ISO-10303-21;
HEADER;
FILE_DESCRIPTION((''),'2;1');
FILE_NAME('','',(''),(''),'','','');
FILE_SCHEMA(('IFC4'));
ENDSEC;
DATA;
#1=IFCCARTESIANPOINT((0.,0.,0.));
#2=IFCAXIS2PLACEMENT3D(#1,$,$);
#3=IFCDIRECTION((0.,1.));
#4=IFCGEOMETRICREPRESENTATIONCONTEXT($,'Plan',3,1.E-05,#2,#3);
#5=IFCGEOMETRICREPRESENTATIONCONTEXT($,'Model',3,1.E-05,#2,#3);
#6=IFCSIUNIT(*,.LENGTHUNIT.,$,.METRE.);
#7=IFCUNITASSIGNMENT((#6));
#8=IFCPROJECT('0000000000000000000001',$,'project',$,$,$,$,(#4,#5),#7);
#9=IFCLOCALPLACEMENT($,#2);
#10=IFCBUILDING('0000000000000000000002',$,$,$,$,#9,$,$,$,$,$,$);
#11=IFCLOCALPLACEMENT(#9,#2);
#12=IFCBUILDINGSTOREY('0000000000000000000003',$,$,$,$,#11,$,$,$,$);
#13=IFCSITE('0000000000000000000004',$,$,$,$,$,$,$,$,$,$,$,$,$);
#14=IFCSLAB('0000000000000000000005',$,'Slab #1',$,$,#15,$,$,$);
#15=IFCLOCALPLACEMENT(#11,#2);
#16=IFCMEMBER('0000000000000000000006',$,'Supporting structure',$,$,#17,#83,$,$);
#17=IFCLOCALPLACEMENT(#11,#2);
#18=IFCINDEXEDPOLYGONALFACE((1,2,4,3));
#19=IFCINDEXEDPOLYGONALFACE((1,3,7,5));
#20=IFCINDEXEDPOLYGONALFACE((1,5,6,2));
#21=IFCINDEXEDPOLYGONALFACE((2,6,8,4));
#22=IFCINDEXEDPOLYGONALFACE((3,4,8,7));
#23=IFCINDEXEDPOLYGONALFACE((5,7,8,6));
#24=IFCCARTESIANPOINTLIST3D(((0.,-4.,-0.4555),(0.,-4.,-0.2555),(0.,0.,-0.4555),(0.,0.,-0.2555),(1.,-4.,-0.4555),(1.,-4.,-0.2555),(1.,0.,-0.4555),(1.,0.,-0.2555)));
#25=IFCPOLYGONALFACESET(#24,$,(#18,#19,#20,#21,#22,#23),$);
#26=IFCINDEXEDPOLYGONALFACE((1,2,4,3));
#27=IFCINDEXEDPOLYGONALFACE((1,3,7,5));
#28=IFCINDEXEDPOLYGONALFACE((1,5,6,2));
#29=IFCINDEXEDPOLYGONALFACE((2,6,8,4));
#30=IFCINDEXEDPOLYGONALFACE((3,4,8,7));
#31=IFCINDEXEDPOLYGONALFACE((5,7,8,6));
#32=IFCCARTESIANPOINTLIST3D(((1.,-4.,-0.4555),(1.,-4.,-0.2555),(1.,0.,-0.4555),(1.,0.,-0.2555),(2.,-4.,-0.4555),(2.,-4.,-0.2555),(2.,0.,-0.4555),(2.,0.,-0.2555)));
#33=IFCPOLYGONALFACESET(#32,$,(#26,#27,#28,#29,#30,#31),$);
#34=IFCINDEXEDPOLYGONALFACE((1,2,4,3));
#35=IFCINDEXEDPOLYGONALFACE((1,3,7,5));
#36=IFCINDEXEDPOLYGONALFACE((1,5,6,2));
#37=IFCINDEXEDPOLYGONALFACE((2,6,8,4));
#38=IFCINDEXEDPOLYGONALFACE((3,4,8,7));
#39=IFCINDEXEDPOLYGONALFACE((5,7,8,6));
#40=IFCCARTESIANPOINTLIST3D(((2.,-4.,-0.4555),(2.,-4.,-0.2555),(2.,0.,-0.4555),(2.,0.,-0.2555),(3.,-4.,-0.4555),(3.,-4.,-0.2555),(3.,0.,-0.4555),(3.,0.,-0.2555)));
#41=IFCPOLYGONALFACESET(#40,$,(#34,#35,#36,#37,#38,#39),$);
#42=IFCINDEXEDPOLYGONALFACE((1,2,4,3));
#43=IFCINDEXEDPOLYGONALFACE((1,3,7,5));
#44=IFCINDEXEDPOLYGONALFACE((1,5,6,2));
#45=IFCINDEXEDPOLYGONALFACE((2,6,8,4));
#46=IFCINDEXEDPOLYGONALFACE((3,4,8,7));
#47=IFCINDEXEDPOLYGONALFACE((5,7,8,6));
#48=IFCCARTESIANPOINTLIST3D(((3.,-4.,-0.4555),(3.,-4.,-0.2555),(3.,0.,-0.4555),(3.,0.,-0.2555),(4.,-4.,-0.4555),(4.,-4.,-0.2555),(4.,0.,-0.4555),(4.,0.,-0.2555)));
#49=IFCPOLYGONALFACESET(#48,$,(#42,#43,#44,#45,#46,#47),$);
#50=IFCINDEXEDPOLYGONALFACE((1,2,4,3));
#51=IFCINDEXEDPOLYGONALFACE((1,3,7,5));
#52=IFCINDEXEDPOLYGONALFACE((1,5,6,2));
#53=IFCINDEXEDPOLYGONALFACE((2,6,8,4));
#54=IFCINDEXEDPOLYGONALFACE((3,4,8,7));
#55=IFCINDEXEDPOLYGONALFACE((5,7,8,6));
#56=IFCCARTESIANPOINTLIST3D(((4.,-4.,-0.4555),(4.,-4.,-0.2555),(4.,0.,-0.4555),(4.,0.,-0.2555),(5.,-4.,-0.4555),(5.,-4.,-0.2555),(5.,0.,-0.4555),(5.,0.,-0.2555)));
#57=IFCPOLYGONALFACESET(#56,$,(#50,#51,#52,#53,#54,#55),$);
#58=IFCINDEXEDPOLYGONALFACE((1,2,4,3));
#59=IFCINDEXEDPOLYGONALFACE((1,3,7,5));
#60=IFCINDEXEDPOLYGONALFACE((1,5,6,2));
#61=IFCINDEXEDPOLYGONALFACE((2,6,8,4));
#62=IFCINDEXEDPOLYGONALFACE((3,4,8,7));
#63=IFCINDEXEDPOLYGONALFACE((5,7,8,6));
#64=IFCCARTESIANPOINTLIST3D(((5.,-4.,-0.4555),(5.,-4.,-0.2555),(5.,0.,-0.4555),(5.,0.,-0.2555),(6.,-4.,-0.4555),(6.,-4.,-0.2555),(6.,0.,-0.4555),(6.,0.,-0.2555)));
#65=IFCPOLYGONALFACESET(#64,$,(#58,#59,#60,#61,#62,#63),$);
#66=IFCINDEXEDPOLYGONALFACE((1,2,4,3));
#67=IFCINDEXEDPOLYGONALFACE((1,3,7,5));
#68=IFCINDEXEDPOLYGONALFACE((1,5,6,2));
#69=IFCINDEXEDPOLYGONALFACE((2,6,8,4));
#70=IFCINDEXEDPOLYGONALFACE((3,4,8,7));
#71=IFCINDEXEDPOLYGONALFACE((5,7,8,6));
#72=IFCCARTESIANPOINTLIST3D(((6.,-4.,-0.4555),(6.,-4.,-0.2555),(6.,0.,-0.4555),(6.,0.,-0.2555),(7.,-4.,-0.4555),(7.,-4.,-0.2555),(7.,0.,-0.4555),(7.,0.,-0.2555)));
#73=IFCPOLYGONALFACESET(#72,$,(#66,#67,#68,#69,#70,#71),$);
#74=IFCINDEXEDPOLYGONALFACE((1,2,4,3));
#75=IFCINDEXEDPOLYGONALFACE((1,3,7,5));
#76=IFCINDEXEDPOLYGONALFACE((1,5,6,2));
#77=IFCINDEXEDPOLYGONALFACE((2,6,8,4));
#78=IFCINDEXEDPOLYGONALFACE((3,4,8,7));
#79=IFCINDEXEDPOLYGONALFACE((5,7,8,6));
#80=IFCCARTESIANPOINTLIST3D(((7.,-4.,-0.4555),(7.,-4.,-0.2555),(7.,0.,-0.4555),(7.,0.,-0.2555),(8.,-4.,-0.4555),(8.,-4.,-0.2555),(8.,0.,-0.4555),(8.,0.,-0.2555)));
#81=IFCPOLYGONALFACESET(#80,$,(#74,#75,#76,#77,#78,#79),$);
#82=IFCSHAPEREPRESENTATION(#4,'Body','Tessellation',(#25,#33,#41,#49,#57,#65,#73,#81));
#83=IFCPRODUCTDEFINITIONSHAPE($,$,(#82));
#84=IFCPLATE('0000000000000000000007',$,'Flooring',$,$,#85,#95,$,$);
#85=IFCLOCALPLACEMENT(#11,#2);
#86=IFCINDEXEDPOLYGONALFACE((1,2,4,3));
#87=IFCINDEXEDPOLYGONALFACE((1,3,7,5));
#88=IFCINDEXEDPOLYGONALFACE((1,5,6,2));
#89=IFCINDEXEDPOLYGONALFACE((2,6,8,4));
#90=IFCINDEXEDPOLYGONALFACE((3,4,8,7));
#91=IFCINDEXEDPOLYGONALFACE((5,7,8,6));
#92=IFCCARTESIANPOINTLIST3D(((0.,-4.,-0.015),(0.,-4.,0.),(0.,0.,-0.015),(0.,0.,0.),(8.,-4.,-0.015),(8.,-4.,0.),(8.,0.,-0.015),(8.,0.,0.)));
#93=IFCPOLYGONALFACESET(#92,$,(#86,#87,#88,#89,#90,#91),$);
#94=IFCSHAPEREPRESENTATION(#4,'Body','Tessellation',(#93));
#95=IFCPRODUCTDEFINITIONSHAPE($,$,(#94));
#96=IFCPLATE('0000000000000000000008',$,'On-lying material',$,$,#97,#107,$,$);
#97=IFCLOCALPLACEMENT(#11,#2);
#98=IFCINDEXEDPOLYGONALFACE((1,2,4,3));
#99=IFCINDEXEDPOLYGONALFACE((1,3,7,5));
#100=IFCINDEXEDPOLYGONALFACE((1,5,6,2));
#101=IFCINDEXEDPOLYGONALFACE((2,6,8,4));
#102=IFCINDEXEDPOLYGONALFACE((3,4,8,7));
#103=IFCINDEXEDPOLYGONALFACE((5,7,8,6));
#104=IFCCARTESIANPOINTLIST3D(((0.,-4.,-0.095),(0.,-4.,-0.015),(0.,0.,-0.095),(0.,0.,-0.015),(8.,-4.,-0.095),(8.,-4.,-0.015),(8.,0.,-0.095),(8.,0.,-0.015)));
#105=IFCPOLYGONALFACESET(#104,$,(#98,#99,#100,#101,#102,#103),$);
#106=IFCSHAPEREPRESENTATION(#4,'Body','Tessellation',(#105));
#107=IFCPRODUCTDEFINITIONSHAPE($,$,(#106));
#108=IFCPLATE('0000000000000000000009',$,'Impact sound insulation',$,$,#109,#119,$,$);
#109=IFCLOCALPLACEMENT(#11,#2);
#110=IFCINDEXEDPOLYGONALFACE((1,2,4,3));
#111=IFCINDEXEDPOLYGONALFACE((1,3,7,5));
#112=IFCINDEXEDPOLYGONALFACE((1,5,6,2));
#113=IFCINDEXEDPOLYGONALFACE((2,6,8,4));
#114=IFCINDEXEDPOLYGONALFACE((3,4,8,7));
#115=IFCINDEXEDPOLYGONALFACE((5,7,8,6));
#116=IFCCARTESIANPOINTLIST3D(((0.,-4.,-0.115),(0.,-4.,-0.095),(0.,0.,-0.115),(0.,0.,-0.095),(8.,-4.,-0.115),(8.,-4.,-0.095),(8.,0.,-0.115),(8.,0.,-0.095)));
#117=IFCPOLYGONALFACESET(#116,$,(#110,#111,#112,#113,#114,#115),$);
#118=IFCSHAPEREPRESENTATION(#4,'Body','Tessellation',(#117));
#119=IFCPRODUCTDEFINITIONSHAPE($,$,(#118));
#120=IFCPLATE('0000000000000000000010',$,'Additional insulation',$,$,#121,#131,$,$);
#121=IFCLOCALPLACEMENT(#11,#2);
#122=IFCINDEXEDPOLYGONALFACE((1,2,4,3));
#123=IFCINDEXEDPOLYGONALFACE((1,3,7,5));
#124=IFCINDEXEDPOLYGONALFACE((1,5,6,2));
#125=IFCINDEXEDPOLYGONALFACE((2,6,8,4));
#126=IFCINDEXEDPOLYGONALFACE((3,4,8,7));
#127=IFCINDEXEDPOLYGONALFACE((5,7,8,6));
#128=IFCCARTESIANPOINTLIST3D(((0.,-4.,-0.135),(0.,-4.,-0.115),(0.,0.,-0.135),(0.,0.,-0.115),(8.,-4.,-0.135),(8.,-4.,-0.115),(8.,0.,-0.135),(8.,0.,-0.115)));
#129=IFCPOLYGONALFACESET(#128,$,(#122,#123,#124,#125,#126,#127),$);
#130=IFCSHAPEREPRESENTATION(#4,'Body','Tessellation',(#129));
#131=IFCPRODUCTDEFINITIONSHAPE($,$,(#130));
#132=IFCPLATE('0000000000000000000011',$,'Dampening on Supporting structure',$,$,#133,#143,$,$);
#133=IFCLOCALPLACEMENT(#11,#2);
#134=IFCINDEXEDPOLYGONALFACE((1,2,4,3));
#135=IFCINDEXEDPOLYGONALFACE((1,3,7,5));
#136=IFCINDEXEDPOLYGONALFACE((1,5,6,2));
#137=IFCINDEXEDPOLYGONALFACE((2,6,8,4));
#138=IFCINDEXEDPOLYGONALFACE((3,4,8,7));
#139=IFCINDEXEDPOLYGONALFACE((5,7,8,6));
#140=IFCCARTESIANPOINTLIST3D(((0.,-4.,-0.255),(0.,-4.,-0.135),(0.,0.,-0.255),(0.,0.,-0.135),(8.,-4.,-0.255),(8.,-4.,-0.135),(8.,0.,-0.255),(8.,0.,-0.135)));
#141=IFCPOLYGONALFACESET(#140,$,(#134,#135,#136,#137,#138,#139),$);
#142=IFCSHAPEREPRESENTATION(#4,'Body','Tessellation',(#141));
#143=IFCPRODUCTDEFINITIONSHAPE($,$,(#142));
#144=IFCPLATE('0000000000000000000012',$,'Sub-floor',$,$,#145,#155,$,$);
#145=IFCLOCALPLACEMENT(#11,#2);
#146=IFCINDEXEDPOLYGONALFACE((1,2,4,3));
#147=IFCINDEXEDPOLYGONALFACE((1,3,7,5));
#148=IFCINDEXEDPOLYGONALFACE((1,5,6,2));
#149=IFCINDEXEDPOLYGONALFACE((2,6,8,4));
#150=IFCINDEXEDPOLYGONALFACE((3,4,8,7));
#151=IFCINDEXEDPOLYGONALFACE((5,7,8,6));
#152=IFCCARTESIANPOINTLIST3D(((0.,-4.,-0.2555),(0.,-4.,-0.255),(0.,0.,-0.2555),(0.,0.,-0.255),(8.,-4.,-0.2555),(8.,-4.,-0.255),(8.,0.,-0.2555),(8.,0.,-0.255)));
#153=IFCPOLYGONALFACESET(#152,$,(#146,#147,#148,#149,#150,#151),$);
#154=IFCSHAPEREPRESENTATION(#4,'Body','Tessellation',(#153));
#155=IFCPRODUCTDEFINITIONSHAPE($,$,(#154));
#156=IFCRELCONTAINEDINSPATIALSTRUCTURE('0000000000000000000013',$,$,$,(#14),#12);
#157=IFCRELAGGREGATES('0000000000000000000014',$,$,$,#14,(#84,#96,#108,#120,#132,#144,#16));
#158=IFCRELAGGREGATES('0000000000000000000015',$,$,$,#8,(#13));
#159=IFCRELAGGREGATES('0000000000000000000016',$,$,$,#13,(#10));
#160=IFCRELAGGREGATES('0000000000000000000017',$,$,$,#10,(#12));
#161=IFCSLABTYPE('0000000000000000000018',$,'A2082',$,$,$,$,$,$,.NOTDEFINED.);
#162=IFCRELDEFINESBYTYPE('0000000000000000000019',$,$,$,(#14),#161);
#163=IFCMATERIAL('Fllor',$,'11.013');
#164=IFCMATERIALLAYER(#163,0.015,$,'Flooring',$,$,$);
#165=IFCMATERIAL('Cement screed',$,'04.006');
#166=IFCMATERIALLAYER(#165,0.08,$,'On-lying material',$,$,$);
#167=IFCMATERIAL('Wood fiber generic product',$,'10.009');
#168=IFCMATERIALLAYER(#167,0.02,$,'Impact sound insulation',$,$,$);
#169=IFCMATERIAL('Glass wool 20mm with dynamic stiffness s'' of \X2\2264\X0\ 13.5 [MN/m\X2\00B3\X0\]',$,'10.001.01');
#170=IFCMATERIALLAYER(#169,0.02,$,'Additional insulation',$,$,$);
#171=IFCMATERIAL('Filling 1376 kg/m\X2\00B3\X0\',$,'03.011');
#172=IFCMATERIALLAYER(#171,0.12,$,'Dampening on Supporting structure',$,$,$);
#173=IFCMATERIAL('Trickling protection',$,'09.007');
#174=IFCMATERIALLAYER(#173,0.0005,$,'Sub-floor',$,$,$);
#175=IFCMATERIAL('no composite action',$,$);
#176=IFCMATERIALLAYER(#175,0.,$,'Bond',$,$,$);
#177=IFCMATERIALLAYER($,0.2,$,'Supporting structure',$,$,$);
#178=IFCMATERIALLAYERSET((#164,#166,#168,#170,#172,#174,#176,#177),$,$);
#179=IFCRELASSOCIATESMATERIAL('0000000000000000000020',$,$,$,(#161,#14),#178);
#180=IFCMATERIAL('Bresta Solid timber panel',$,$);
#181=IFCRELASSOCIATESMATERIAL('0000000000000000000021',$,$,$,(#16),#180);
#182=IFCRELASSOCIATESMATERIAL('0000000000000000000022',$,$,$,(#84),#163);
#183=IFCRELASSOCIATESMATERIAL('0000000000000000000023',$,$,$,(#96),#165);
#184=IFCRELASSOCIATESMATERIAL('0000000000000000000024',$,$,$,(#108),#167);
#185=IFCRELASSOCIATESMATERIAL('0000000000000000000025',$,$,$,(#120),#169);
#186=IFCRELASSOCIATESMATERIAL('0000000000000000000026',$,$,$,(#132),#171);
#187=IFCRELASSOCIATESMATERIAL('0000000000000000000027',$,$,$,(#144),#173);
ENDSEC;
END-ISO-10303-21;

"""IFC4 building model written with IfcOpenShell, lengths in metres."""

from ifc_helpers import new_model, si_unit, direction, frame, frame_2d, origin, origin_with_axes, place, context, project, spatial, rectangle, extrude, material, layer, layer_set, type_object, element, aggregate, save


model = new_model("IFC4")

# Units and contexts
plan_context = context("Plan", 3, precision=1e-05, world=origin(), true_north=direction((0.0, 1.0)))
model_context = context("Model", 3, precision=1e-05, world=origin(), true_north=direction((0.0, 1.0)))
ifc_project = project(units=[si_unit("LENGTHUNIT", "METRE")], contexts=[plan_context, model_context])

# Site, building, storey
site = spatial("IfcSite", under=ifc_project)
building_placement = place(None, origin())
building = spatial("IfcBuilding", under=site, at=building_placement)
storey_placement = place(building_placement, origin())
storey = spatial("IfcBuildingStorey", under=building, at=storey_placement)

# Slab, member, plates
ifc_material_1 = material(Name="Fllor", Category="11.013")
ifc_layer_1 = layer(ifc_material_1, 0.015, Name="Flooring")
ifc_material_2 = material(Name="Cement screed", Category="04.006")
ifc_layer_2 = layer(ifc_material_2, 0.08, Name="On-lying material")
ifc_material_3 = material(Name="Wood fiber generic product", Category="10.009")
ifc_layer_3 = layer(ifc_material_3, 0.02, Name="Impact sound insulation")
ifc_material_4 = material(Name="Glass wool 20mm with dynamic stiffness s' of ≤ 13.5 [MN/m³]", Category="10.001.01")
ifc_layer_4 = layer(ifc_material_4, 0.02, Name="Additional insulation")
ifc_material_5 = material(Name="Filling 1376 kg/m³", Category="03.011")
ifc_layer_5 = layer(ifc_material_5, 0.12, Name="Dampening on Supporting structure")
ifc_material_6 = material(Name="Trickling protection", Category="09.007")
ifc_layer_6 = layer(ifc_material_6, 0.0005, Name="Sub-floor")
ifc_material_7 = material(Name="no composite action")
ifc_layer_7 = layer(ifc_material_7, 0.0, Name="Bond")
ifc_layer_8 = layer(None, 0.2, Name="Supporting structure")
ifc_layer_set = layer_set([ifc_layer_1, ifc_layer_2, ifc_layer_3, ifc_layer_4, ifc_layer_5, ifc_layer_6, ifc_layer_7, ifc_layer_8])
slab_type = type_object("IfcSlabType", Name="A2082", PredefinedType="NOTDEFINED", material=ifc_layer_set)
slab_placement = place(None, frame((0.0, 0.0, 0.0), z_axis=(0.0, 0.0, -1.0), x_axis=(1.0, 0.0, 0.0)))
slab = element("IfcSlab", 1, at=slab_placement, inside=storey, type_object=slab_type, material=ifc_layer_set, Name="Slab #1")
ifc_material_8 = material(Name="Bresta Solid timber panel")
member_placement = place(slab_placement, origin())
member = element("IfcMember", 2, at=member_placement, material=ifc_material_8, Name="Supporting structure", context=plan_context, shape_type="SweptSolid", body=[
    extrude(rectangle(XDim=1.0, YDim=0.2, at=frame_2d((0.5, 0.1), x_axis=(1.0, 0.0))), frame((0.0, 4.0, 0.2555), z_axis=(0.0, -1.0, 0.0), x_axis=(1.0, 0.0, 0.0)), (0.0, 0.0, 1.0), 4.0),
    extrude(rectangle(XDim=1.0, YDim=0.2, at=frame_2d((0.5, 0.1), x_axis=(1.0, 0.0))), frame((1.0, 4.0, 0.2555), z_axis=(0.0, -1.0, 0.0), x_axis=(1.0, 0.0, 0.0)), (0.0, 0.0, 1.0), 4.0),
    extrude(rectangle(XDim=1.0, YDim=0.2, at=frame_2d((0.5, 0.1), x_axis=(1.0, 0.0))), frame((2.0, 4.0, 0.2555), z_axis=(0.0, -1.0, 0.0), x_axis=(1.0, 0.0, 0.0)), (0.0, 0.0, 1.0), 4.0),
    extrude(rectangle(XDim=1.0, YDim=0.2, at=frame_2d((0.5, 0.1), x_axis=(1.0, 0.0))), frame((3.0, 4.0, 0.2555), z_axis=(0.0, -1.0, 0.0), x_axis=(1.0, 0.0, 0.0)), (0.0, 0.0, 1.0), 4.0),
    extrude(rectangle(XDim=1.0, YDim=0.2, at=frame_2d((0.5, 0.1), x_axis=(1.0, 0.0))), frame((4.0, 4.0, 0.2555), z_axis=(0.0, -1.0, 0.0), x_axis=(1.0, 0.0, 0.0)), (0.0, 0.0, 1.0), 4.0),
    extrude(rectangle(XDim=1.0, YDim=0.2, at=frame_2d((0.5, 0.1), x_axis=(1.0, 0.0))), frame((5.0, 4.0, 0.2555), z_axis=(0.0, -1.0, 0.0), x_axis=(1.0, 0.0, 0.0)), (0.0, 0.0, 1.0), 4.0),
    extrude(rectangle(XDim=1.0, YDim=0.2, at=frame_2d((0.5, 0.1), x_axis=(1.0, 0.0))), frame((6.0, 4.0, 0.2555), z_axis=(0.0, -1.0, 0.0), x_axis=(1.0, 0.0, 0.0)), (0.0, 0.0, 1.0), 4.0),
    extrude(rectangle(XDim=1.0, YDim=0.2, at=frame_2d((0.5, 0.1), x_axis=(1.0, 0.0))), frame((7.0, 4.0, 0.2555), z_axis=(0.0, -1.0, 0.0), x_axis=(1.0, 0.0, 0.0)), (0.0, 0.0, 1.0), 4.0),
])
plate_1_placement = place(slab_placement, origin())
plate_1 = element("IfcPlate", 3, at=plate_1_placement, material=ifc_material_1, Name="Flooring", context=plan_context, shape_type="SweptSolid", body=[
    extrude(rectangle(XDim=8.0, YDim=4.0, at=frame_2d((4.0, 2.0), x_axis=(1.0, 0.0))), origin_with_axes(), (0.0, 0.0, 1.0), 0.015),
])
plate_2_placement = place(slab_placement, origin())
plate_2 = element("IfcPlate", 4, at=plate_2_placement, material=ifc_material_2, Name="On-lying material", context=plan_context, shape_type="SweptSolid", body=[
    extrude(rectangle(XDim=8.0, YDim=4.0, at=frame_2d((4.0, 2.0), x_axis=(1.0, 0.0))), frame((0.0, 0.0, 0.015), z_axis=(0.0, 0.0, 1.0), x_axis=(1.0, 0.0, 0.0)), (0.0, 0.0, 1.0), 0.08),
])
plate_3_placement = place(slab_placement, origin())
plate_3 = element("IfcPlate", 5, at=plate_3_placement, material=ifc_material_3, Name="Impact sound insulation", context=plan_context, shape_type="SweptSolid", body=[
    extrude(rectangle(XDim=8.0, YDim=4.0, at=frame_2d((4.0, 2.0), x_axis=(1.0, 0.0))), frame((0.0, 0.0, 0.095), z_axis=(0.0, 0.0, 1.0), x_axis=(1.0, 0.0, 0.0)), (0.0, 0.0, 1.0), 0.02),
])
plate_4_placement = place(slab_placement, origin())
plate_4 = element("IfcPlate", 6, at=plate_4_placement, material=ifc_material_4, Name="Additional insulation", context=plan_context, shape_type="SweptSolid", body=[
    extrude(rectangle(XDim=8.0, YDim=4.0, at=frame_2d((4.0, 2.0), x_axis=(1.0, 0.0))), frame((0.0, 0.0, 0.115), z_axis=(0.0, 0.0, 1.0), x_axis=(1.0, 0.0, 0.0)), (0.0, 0.0, 1.0), 0.02),
])
plate_5_placement = place(slab_placement, origin())
plate_5 = element("IfcPlate", 7, at=plate_5_placement, material=ifc_material_5, Name="Dampening on Supporting structure", context=plan_context, shape_type="SweptSolid", body=[
    extrude(rectangle(XDim=8.0, YDim=4.0, at=frame_2d((4.0, 2.0), x_axis=(1.0, 0.0))), frame((0.0, 0.0, 0.135), z_axis=(0.0, 0.0, 1.0), x_axis=(1.0, 0.0, 0.0)), (0.0, 0.0, 1.0), 0.12),
])
plate_6_placement = place(slab_placement, origin())
plate_6 = element("IfcPlate", 8, at=plate_6_placement, material=ifc_material_6, Name="Sub-floor", context=plan_context, shape_type="SweptSolid", body=[
    extrude(rectangle(XDim=8.0, YDim=4.0, at=frame_2d((4.0, 2.0), x_axis=(1.0, 0.0))), frame((0.0, 0.0, 0.255), z_axis=(0.0, 0.0, 1.0), x_axis=(1.0, 0.0, 0.0)), (0.0, 0.0, 1.0), 0.0005),
])
aggregate(slab, [plate_1, plate_2, plate_3, plate_4, plate_5, plate_6, member])

save(model, "model.ifc")
